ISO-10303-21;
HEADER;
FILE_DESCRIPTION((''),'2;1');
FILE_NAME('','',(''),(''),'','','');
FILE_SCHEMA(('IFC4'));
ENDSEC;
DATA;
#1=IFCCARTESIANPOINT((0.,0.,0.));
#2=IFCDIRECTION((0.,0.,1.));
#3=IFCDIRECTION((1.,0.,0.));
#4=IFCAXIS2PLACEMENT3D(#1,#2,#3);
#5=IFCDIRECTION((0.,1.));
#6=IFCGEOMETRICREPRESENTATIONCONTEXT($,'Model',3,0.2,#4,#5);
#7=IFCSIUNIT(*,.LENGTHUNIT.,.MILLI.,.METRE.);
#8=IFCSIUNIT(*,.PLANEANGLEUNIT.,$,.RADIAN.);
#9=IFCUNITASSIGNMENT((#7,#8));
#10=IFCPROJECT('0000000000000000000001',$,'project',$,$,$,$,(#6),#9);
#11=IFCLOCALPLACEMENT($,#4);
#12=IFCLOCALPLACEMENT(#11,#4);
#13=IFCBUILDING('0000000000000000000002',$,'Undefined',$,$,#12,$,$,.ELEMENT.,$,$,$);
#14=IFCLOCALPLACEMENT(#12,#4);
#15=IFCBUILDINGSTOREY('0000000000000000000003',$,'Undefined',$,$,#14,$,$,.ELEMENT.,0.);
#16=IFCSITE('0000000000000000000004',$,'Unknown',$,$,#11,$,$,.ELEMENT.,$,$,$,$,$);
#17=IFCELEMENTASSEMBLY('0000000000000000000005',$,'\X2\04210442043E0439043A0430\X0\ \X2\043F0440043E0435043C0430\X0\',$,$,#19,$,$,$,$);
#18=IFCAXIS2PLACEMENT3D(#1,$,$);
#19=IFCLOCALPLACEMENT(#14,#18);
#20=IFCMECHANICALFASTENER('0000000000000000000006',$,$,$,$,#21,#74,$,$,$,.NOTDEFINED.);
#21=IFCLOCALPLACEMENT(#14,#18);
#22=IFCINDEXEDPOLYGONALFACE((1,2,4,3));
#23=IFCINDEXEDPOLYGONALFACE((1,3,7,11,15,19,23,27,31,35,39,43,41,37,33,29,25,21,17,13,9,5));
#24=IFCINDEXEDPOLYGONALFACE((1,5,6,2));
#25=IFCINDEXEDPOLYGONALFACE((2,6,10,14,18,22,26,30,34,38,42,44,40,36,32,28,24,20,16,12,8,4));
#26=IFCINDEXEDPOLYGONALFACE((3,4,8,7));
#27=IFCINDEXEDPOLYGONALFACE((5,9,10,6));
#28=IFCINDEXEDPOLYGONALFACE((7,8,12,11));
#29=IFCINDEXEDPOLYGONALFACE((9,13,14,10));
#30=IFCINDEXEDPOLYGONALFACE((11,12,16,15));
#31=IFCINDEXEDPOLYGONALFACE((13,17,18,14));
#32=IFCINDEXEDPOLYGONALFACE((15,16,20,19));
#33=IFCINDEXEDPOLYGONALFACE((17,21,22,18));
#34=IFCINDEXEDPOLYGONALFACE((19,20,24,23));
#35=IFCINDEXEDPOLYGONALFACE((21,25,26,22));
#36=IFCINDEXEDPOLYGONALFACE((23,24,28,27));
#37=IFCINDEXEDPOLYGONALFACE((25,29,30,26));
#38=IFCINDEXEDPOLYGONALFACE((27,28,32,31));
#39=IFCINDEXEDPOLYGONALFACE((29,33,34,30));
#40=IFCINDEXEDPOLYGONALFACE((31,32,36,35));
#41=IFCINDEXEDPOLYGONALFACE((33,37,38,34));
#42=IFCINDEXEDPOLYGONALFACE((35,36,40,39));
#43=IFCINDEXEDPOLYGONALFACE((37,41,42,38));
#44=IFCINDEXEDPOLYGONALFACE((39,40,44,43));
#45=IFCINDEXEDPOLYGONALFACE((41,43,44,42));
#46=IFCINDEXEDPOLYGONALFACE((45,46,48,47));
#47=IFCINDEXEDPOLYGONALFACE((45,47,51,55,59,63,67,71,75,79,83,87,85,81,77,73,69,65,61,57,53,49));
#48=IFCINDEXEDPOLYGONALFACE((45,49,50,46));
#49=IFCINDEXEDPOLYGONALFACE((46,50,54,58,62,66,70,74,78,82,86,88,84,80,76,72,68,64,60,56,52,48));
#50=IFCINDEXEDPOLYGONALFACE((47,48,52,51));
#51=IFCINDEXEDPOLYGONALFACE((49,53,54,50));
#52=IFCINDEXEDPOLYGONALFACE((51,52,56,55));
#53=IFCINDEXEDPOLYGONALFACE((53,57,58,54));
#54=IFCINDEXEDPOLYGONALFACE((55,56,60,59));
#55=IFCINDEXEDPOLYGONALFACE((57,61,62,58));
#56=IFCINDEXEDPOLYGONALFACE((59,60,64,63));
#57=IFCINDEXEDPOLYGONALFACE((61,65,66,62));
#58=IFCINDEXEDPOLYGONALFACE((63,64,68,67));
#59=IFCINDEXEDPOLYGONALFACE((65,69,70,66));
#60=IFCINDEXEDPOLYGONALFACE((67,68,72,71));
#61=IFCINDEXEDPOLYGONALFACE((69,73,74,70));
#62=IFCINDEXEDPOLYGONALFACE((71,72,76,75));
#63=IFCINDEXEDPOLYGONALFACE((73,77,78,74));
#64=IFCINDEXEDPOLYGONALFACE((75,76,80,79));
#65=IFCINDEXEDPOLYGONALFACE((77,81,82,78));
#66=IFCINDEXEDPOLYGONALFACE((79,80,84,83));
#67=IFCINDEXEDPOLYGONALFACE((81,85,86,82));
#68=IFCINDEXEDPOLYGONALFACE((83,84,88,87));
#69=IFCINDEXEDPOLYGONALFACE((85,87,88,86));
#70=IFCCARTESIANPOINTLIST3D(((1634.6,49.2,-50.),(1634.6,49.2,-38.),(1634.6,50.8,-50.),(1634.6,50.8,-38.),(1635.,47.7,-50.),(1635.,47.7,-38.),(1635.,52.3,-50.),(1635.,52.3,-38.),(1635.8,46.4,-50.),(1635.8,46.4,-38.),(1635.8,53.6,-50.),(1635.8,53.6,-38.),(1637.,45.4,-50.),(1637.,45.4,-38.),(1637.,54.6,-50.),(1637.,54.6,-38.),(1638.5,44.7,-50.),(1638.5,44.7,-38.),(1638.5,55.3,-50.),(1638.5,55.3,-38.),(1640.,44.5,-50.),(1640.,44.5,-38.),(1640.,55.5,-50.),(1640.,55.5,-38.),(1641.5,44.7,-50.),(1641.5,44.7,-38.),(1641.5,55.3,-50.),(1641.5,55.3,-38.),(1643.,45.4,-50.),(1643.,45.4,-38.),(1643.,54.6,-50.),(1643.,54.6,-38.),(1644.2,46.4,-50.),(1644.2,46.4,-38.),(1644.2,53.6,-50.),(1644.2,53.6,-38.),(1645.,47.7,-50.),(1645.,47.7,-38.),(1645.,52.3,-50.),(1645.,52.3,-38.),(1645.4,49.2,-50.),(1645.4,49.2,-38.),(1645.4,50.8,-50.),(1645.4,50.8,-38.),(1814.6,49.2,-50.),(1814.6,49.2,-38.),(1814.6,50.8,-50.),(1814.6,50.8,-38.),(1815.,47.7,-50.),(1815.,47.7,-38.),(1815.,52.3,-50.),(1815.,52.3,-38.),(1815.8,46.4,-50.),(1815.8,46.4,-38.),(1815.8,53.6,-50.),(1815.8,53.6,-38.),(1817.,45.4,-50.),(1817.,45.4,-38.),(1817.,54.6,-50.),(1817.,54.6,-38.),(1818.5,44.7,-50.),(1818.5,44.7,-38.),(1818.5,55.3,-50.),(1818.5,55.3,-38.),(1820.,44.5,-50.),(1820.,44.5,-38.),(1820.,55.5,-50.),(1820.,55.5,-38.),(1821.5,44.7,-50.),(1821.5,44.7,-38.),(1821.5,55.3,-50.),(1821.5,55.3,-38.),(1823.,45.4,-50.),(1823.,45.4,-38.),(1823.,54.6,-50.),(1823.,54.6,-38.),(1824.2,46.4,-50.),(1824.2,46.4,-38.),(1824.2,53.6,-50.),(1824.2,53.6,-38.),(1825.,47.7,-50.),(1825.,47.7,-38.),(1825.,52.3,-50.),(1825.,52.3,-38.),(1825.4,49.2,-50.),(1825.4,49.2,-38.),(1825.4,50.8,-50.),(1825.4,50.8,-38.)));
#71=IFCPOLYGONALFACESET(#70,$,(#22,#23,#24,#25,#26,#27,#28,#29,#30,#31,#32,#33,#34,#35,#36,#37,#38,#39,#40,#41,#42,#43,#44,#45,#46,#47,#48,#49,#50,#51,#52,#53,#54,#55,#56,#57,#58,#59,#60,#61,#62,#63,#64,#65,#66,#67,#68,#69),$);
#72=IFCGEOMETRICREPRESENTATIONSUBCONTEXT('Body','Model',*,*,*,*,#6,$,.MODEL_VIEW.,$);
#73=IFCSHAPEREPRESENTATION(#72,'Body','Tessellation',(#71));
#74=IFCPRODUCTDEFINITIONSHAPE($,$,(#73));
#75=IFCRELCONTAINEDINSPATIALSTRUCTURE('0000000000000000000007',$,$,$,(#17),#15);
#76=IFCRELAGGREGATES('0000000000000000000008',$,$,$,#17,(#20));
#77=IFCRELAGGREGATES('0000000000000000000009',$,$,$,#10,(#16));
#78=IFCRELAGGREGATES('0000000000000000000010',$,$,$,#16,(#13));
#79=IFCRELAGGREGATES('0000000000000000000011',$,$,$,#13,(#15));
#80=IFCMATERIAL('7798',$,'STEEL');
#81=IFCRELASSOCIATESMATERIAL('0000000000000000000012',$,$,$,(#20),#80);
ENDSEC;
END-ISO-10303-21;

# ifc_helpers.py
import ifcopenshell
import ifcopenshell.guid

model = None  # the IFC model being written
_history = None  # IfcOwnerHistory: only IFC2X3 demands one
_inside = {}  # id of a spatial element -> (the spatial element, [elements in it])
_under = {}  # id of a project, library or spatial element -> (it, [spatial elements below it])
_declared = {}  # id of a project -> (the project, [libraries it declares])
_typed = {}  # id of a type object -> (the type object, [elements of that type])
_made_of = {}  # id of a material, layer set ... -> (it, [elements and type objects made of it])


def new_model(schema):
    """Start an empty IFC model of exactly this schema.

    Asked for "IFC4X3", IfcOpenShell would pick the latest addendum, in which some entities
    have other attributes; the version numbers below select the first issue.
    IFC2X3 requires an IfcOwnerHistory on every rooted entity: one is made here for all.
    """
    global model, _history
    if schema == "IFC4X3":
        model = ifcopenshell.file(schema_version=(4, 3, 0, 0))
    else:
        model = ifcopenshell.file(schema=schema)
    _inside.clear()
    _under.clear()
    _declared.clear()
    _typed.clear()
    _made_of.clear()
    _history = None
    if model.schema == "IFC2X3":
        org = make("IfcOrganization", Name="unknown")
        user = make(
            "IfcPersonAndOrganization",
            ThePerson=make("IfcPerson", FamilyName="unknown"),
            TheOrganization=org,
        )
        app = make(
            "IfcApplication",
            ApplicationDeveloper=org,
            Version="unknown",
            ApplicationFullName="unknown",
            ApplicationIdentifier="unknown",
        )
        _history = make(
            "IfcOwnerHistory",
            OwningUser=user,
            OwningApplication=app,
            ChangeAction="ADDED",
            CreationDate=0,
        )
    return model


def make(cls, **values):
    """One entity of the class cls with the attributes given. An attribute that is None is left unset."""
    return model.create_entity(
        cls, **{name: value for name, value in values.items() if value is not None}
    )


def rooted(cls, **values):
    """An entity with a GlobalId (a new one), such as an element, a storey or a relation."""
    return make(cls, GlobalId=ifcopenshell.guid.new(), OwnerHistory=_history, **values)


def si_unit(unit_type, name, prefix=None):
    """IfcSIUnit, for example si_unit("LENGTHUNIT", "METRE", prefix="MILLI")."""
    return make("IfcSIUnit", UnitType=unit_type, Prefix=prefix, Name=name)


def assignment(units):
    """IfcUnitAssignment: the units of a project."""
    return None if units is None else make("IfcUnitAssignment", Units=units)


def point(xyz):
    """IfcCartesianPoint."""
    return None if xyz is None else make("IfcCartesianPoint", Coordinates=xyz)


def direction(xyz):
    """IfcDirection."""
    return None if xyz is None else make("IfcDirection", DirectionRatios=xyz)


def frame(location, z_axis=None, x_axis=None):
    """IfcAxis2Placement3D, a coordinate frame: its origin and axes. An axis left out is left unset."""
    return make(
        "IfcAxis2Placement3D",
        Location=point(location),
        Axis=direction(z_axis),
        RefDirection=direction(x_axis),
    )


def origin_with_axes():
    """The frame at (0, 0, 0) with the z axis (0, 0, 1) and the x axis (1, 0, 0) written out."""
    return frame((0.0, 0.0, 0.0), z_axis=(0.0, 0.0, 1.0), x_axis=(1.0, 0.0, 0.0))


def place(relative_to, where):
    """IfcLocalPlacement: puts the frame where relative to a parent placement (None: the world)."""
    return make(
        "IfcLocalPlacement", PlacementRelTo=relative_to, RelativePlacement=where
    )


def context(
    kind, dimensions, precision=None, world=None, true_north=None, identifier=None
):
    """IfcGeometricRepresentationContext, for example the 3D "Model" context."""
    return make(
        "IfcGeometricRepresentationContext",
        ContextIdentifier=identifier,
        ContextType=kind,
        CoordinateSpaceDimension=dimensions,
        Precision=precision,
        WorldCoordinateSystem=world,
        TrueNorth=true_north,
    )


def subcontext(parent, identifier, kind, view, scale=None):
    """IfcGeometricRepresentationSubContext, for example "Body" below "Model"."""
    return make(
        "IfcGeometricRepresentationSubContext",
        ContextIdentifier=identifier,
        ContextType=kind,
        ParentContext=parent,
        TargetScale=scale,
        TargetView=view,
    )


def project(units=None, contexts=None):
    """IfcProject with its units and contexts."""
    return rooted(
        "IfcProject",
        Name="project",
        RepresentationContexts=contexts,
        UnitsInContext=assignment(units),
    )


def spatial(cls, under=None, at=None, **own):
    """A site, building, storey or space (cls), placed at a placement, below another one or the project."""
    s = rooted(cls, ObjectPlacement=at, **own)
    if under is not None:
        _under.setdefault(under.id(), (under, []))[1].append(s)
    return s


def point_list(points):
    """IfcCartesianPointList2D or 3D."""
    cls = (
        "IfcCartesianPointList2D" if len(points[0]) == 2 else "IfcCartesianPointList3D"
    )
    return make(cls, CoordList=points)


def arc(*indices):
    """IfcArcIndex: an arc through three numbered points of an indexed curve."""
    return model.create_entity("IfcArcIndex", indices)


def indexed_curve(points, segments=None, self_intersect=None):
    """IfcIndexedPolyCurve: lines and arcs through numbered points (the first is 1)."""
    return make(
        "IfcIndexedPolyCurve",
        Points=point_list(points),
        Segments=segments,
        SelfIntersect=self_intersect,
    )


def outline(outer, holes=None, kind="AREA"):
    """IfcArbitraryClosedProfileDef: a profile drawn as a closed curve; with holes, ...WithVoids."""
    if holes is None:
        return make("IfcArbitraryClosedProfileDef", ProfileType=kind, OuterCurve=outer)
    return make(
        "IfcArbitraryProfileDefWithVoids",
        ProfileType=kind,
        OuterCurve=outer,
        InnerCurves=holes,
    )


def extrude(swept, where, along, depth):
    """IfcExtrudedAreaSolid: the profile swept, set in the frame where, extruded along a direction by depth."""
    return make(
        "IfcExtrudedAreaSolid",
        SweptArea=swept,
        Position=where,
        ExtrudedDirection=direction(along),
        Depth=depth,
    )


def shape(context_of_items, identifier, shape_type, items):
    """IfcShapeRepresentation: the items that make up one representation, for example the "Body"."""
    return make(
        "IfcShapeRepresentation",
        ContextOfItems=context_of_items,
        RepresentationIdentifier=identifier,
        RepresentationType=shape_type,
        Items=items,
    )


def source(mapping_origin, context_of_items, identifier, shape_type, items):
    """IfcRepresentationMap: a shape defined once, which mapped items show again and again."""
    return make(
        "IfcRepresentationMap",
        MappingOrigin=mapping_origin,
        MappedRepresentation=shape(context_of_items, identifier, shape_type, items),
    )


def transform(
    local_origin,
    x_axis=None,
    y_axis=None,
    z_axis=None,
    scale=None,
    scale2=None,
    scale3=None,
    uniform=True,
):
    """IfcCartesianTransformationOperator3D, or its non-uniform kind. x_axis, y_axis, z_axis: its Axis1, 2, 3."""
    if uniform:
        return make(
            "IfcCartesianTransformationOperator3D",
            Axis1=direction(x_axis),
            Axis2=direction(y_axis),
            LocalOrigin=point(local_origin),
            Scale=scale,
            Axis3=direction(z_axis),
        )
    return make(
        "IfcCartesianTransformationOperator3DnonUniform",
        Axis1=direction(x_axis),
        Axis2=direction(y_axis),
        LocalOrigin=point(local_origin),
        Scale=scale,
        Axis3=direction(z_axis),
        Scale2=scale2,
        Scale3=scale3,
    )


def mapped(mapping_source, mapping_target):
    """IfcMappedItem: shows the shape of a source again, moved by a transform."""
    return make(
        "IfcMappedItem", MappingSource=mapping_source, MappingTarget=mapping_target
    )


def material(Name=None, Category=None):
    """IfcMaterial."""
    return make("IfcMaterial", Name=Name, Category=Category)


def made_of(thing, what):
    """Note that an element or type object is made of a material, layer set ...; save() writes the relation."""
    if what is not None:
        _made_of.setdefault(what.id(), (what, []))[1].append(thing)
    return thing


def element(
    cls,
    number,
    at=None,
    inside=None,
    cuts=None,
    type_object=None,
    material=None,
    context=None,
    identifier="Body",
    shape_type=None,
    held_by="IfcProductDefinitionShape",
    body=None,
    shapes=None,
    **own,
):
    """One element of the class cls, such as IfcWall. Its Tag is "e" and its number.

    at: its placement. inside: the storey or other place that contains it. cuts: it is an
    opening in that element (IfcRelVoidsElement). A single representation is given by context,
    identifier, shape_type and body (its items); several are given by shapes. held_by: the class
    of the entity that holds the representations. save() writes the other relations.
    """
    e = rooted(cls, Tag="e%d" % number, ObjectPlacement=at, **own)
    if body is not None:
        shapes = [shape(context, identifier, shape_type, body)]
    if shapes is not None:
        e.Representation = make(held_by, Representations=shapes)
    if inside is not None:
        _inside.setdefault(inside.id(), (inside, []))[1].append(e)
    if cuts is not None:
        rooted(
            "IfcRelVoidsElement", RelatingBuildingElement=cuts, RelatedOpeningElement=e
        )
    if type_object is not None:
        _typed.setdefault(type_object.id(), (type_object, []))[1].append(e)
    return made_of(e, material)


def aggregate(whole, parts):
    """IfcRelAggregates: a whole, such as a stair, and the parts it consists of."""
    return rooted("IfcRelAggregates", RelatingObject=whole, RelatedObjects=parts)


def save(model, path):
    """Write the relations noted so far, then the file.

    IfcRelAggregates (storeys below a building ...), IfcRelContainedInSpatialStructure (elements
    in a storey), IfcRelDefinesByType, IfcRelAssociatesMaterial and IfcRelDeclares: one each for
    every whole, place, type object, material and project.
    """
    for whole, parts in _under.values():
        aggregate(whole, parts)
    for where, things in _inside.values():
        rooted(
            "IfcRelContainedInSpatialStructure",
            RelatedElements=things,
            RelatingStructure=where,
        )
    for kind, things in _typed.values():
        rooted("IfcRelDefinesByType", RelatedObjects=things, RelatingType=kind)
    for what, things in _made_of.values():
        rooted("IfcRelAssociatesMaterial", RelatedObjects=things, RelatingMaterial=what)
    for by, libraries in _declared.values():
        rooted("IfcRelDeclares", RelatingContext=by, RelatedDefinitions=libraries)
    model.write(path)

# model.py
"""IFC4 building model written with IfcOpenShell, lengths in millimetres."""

from ifc_helpers import new_model, si_unit, direction, frame, origin_with_axes, place, context, subcontext, project, spatial, arc, indexed_curve, outline, extrude, source, transform, mapped, material, element, aggregate, save


model = new_model("IFC4")

# Units and contexts
model_context = context("Model", 3, precision=0.2, world=origin_with_axes(), true_north=direction((0.0, 1.0)))
body_context = subcontext(model_context, "Body", "Model", "MODEL_VIEW")
ifc_project = project(units=[si_unit("LENGTHUNIT", "METRE", prefix="MILLI"), si_unit("PLANEANGLEUNIT", "RADIAN")], contexts=[model_context])

# Site, building, storey
site_placement = place(None, origin_with_axes())
site = spatial("IfcSite", under=ifc_project, at=site_placement, Name="Unknown", CompositionType="ELEMENT")
building_placement = place(site_placement, origin_with_axes())
building = spatial("IfcBuilding", under=site, at=building_placement, Name="Undefined", CompositionType="ELEMENT")
storey_placement = place(building_placement, origin_with_axes())
storey = spatial("IfcBuildingStorey", under=building, at=storey_placement, Name="Undefined", CompositionType="ELEMENT", Elevation=0.0)

# Element assembly
assembly_1_placement = place(storey_placement, frame((1730.0, 50.0, -50.0), z_axis=(1.0, 0.0, 0.0), x_axis=(0.0, 0.0, 1.0)))
assembly_1 = element("IfcElementAssembly", 1, at=assembly_1_placement, inside=storey, Name="Стойка проема")

# Mechanical fastener
ifc_material_1 = material(Name="7798", Category="STEEL")
shared_shape_1 = source(origin_with_axes(), body_context, "Body", "SweptSolid", [
    extrude(outline(indexed_curve([(5.5, 0.0), (0.0, 5.5), (-5.5, 0.0), (0.0, -5.5)], segments=[arc(1, 2, 3), arc(3, 4, 1)])), frame((0.0, 0.0, 0.0), z_axis=(0.0, 0.0, -1.0), x_axis=(0.0, 1.0, 0.0)), (0.0, 0.0, 1.0), 12.0),
])
mechanical_fastener_1_placement = place(assembly_1_placement, frame((12.0, 0.0, -90.0), z_axis=(1.0, 0.0, 0.0), x_axis=(0.0, 0.0, 1.0)))
mechanical_fastener_1 = element("IfcMechanicalFastener", 2, at=mechanical_fastener_1_placement, material=ifc_material_1, PredefinedType="NOTDEFINED", context=body_context, shape_type="MappedRepresentation", body=[
    mapped(shared_shape_1, transform((0.0, 0.0, 0.0))),
    mapped(shared_shape_1, transform((180.0, 0.0, 0.0))),
])
aggregate(assembly_1, [mechanical_fastener_1])

save(model, "model.ifc")
